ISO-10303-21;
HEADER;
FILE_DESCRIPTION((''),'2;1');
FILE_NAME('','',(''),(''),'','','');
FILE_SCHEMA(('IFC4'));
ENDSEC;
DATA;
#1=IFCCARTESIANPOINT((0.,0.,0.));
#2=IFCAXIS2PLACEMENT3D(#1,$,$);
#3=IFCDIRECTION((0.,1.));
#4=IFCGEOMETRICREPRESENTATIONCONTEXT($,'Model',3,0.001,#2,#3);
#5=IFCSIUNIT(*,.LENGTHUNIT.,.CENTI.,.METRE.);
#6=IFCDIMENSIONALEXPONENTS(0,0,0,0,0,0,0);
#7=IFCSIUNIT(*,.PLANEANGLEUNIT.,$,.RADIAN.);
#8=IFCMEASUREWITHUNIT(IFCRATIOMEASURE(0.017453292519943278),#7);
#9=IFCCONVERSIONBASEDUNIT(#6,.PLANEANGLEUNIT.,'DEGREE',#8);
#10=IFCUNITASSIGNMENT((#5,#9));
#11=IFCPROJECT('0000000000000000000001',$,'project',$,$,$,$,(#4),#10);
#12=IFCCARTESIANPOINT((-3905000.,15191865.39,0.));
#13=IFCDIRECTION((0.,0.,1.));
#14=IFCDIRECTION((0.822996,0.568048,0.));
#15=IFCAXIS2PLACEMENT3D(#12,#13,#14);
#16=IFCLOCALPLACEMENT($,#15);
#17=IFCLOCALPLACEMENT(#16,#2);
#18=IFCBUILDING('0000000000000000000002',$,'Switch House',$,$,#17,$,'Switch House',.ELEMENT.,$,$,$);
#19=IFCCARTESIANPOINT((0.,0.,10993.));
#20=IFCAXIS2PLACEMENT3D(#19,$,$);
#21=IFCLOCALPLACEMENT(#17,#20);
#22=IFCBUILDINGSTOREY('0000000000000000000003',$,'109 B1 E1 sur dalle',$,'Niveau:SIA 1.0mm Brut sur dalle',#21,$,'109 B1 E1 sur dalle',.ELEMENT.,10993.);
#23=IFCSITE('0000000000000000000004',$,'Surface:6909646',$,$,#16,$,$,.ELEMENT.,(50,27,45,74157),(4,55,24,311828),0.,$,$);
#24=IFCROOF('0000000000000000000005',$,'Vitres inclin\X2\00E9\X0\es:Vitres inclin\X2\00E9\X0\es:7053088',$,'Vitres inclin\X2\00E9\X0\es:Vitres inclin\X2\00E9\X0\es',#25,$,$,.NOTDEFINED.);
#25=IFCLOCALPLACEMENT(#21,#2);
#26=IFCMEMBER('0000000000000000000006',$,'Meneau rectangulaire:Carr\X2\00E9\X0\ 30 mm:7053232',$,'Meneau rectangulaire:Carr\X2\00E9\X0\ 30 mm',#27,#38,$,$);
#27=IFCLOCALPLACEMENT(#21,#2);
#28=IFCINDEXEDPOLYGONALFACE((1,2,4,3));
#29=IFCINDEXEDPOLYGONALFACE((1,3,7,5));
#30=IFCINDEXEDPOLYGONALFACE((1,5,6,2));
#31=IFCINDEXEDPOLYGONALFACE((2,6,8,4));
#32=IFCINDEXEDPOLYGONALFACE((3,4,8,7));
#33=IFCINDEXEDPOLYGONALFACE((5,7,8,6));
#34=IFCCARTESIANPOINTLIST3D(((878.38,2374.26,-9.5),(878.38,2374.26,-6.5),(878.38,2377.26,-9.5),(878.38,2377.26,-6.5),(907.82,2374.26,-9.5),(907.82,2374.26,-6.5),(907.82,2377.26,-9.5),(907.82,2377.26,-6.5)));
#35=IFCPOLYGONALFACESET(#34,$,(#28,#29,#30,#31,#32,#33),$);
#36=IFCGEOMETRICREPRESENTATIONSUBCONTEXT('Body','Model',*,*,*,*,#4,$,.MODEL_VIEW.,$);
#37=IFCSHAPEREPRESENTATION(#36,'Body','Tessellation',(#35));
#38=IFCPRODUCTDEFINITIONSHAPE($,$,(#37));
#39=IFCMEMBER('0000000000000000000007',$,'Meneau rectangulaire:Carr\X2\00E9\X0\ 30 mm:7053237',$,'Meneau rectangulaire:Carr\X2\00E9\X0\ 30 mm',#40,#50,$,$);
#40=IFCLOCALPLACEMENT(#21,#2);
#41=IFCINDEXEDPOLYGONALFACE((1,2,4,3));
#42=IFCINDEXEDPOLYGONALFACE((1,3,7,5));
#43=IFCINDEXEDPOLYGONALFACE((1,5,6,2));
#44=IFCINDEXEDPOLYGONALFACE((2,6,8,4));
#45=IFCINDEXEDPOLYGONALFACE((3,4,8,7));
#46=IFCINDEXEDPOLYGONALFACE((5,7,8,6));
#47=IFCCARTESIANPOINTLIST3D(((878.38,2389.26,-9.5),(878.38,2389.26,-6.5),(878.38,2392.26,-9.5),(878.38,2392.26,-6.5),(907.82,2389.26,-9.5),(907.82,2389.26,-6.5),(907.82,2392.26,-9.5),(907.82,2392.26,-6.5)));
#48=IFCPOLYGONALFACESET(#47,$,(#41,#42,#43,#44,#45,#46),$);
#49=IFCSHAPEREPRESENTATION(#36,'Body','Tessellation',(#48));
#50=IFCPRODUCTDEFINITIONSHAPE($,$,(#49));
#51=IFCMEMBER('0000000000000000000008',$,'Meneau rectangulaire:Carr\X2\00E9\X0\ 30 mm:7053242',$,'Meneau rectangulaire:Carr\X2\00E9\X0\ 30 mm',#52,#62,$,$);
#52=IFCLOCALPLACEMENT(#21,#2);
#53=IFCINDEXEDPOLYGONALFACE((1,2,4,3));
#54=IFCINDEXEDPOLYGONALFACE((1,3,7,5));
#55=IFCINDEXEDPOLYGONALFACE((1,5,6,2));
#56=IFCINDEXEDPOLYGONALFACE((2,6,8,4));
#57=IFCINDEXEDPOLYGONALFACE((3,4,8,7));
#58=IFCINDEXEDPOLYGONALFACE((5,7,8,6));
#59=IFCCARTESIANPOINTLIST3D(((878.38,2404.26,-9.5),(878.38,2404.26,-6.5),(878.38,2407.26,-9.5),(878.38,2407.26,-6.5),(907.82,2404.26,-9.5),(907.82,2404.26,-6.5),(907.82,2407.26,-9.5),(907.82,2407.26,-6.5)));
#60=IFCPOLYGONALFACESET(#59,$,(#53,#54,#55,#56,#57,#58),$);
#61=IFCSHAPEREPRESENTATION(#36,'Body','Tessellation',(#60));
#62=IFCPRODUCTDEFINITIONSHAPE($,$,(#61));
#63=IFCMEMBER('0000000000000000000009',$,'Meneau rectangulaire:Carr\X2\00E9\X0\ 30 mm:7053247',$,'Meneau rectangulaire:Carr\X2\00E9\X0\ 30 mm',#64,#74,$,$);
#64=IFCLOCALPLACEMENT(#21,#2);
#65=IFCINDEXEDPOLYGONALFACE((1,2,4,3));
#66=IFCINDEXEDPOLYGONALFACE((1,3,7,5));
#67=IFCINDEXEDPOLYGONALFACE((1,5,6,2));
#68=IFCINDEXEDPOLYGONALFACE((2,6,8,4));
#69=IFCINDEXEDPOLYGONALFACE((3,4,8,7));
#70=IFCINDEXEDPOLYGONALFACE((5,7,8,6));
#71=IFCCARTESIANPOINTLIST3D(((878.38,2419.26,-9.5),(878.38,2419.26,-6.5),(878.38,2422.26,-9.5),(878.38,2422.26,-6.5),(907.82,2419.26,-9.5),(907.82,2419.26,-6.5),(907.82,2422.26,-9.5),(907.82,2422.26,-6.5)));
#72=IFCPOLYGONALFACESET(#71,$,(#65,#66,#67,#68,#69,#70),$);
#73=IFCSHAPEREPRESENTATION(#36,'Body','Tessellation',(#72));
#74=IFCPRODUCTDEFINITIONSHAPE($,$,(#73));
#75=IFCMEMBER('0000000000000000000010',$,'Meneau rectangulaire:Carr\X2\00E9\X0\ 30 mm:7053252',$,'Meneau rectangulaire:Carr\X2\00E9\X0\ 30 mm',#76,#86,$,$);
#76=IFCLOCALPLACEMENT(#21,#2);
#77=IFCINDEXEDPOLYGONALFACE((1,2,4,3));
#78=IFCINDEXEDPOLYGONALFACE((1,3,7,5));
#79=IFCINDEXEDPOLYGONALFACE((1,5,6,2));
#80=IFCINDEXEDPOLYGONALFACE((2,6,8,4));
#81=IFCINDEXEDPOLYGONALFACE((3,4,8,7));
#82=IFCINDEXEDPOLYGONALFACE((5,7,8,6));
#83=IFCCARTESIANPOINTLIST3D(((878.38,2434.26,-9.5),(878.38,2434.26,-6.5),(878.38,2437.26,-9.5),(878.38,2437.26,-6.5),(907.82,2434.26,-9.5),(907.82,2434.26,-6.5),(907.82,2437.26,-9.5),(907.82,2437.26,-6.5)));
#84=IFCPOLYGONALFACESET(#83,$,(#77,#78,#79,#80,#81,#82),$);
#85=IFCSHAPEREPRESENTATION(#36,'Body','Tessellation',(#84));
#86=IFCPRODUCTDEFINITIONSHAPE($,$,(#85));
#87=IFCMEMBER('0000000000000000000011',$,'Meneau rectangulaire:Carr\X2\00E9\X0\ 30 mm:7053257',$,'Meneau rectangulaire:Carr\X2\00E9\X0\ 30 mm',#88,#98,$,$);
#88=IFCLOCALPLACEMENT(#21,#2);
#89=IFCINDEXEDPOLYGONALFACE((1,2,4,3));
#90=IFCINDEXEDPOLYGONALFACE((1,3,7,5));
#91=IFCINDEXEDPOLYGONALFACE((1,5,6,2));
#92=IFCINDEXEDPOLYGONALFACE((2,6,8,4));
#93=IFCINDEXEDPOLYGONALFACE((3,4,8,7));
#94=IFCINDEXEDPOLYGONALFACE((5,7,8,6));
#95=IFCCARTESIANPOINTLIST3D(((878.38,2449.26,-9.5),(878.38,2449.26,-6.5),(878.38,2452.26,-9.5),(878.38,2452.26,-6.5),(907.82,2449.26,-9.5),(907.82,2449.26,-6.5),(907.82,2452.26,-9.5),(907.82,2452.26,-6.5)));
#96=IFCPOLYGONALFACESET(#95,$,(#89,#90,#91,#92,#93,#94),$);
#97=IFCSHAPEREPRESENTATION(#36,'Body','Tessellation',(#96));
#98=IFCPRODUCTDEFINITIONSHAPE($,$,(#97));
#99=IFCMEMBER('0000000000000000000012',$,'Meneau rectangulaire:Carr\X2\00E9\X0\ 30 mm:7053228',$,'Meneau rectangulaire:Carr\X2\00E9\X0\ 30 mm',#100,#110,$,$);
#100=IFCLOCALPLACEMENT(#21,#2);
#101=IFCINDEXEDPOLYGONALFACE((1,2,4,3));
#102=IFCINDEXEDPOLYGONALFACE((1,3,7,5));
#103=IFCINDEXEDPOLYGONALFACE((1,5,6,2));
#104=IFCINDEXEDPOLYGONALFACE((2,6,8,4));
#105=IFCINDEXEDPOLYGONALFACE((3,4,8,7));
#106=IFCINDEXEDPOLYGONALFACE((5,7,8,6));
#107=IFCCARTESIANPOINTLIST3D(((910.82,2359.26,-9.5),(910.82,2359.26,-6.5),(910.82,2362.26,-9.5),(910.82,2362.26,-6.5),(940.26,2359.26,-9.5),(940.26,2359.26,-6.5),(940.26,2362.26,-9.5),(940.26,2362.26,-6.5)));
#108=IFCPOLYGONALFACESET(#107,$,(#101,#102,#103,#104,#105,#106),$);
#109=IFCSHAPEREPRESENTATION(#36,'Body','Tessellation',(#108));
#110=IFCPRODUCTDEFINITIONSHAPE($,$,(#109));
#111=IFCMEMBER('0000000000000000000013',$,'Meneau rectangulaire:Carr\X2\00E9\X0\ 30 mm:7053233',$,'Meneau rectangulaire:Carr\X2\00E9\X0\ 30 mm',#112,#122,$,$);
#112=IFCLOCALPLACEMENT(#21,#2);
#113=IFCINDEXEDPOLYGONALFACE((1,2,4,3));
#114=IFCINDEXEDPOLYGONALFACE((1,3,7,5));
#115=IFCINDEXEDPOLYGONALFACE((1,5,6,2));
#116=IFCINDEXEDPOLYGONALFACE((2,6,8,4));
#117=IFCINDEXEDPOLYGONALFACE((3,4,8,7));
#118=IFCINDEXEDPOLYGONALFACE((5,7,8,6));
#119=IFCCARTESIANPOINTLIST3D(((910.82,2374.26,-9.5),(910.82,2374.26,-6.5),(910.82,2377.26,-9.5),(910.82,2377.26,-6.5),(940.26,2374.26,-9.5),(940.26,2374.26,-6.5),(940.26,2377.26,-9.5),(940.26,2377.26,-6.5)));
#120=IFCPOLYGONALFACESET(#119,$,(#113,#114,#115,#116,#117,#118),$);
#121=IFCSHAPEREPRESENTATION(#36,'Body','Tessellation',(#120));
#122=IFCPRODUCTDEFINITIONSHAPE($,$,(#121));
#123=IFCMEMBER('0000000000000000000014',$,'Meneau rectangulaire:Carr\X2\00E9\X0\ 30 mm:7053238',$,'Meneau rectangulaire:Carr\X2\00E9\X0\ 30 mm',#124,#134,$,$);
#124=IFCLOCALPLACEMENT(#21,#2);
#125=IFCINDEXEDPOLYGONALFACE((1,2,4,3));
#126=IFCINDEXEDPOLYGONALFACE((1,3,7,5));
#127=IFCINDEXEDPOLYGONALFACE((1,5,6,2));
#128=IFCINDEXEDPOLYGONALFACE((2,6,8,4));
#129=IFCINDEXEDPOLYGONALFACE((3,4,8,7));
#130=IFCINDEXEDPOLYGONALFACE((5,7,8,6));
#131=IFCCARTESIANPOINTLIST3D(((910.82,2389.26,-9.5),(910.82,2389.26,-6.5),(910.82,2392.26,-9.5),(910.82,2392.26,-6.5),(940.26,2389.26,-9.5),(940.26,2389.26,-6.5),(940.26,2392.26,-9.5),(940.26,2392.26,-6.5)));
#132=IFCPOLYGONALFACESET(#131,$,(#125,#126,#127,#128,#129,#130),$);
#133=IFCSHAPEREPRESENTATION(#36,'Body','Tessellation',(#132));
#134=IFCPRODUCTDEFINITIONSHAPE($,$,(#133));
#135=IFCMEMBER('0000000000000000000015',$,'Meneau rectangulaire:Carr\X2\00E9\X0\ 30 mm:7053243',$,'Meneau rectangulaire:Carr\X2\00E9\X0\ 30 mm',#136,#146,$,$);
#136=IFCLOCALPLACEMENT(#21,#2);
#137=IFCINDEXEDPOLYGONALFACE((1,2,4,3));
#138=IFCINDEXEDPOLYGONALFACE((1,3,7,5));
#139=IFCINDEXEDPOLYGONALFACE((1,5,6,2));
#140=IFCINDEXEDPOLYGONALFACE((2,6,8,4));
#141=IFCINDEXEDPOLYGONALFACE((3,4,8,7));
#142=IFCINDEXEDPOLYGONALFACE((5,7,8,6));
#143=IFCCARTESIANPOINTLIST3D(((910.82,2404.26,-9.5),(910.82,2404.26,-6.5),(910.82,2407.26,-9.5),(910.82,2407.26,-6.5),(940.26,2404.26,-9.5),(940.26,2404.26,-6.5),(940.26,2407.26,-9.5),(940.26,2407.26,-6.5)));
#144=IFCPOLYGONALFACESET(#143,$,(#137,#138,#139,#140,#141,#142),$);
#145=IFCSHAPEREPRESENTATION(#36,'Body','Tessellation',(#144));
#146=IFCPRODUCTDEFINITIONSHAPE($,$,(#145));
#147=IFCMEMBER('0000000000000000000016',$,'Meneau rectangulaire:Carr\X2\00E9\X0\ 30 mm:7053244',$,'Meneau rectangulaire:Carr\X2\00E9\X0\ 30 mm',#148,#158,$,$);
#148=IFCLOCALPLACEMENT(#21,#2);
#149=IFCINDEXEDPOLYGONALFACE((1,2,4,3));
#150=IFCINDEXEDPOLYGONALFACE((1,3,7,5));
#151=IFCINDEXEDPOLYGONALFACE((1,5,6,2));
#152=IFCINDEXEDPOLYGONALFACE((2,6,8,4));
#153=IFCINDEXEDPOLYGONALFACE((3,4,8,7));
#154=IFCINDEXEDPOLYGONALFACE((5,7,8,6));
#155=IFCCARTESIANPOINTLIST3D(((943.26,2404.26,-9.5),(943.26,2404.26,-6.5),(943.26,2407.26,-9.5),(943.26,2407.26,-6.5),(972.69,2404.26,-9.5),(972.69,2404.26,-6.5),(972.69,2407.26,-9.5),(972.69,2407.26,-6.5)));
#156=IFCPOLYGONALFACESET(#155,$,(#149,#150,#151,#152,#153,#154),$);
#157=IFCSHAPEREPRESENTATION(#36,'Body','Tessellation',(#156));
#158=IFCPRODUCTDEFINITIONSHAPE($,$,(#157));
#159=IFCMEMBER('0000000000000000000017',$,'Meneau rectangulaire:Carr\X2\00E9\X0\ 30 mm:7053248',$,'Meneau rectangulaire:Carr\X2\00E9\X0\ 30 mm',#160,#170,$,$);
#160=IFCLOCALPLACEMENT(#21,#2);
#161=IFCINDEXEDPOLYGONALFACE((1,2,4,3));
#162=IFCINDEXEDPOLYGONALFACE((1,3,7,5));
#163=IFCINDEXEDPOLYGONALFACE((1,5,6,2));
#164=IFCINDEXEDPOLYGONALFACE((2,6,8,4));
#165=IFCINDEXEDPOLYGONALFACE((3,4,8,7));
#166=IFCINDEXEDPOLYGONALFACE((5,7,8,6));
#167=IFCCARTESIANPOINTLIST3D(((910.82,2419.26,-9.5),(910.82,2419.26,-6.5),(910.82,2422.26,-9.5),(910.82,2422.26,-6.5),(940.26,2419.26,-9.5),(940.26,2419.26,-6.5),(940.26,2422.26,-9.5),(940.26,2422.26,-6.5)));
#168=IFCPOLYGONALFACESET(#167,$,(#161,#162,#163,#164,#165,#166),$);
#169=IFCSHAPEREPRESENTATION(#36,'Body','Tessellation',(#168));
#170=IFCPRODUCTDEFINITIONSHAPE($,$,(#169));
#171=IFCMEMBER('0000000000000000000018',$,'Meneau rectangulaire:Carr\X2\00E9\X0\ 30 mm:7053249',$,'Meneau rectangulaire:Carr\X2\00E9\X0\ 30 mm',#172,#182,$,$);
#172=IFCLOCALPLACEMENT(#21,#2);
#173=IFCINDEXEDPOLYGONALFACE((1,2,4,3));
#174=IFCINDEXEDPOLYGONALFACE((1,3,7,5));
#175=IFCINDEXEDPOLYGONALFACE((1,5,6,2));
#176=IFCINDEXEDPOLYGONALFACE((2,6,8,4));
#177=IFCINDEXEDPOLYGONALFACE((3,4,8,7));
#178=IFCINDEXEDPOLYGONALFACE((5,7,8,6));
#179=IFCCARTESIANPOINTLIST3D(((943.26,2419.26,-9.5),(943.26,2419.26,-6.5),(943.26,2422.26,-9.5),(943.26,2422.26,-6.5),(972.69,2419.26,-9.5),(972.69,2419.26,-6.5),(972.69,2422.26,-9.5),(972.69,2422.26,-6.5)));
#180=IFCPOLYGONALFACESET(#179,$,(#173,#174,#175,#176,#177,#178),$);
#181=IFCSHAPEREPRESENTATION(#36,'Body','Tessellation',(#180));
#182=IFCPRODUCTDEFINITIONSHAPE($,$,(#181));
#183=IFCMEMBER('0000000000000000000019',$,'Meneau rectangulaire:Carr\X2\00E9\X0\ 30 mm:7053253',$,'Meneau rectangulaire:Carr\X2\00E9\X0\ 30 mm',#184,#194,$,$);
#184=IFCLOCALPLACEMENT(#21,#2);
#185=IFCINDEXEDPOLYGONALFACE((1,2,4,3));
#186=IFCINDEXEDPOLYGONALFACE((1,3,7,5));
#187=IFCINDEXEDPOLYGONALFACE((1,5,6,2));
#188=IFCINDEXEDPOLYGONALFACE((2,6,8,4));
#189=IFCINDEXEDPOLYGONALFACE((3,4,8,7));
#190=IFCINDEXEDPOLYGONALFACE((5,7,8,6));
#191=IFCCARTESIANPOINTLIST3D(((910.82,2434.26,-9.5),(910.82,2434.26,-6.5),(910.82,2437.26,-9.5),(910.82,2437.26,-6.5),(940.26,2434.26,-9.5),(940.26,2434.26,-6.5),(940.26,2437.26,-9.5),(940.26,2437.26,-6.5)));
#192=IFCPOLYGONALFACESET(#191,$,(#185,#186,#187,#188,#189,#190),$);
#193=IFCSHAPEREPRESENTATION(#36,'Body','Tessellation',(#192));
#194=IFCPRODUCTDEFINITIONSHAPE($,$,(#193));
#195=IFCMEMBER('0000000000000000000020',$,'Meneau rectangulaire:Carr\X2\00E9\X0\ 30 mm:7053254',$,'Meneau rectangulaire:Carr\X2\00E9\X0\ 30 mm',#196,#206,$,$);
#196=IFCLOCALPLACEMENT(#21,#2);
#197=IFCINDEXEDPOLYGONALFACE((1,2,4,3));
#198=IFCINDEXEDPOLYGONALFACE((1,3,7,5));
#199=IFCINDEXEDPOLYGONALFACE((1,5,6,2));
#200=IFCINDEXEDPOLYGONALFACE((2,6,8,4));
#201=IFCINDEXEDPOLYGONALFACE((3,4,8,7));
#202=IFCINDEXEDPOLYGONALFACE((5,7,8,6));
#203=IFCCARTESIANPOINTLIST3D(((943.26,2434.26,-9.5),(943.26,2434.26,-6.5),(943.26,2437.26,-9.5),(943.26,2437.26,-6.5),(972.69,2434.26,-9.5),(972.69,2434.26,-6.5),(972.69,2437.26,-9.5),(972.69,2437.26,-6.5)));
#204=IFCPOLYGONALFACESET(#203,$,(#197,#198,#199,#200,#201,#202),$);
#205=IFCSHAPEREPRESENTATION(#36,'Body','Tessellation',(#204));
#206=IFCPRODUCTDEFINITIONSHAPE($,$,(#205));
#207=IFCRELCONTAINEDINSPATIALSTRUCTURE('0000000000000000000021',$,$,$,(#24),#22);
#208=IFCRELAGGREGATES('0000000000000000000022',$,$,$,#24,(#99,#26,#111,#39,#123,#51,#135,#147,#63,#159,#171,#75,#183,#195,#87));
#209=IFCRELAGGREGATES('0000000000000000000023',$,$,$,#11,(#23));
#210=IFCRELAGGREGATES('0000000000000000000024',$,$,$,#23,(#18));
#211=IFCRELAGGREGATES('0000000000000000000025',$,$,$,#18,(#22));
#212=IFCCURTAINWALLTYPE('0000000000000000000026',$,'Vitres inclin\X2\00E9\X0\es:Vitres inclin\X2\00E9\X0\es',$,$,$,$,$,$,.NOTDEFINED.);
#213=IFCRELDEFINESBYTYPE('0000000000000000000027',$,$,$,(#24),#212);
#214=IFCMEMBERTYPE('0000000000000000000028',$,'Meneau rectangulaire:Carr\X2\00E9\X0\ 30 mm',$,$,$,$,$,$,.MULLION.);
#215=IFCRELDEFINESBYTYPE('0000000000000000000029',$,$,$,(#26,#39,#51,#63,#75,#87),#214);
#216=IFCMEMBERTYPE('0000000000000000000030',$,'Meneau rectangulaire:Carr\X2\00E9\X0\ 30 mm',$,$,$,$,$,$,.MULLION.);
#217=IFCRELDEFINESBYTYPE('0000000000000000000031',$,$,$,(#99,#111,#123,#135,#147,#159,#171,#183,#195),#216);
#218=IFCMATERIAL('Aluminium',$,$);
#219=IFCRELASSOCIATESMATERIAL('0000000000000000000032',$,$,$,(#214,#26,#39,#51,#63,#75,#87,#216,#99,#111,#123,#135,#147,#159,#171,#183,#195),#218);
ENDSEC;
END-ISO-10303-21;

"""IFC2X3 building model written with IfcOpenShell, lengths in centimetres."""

from ifc_helpers import new_model, entity, si_unit, converted_unit, direction, frame, origin, origin_2d_with_axis, place, context, subcontext, project, spatial, rectangle, extrude, source, transform, mapped, material, type_object, type_shapes, element, aggregate, save


model = new_model("IFC2X3")

# Units and contexts
model_context = context("Model", 3, precision=0.001, world=origin(), true_north=direction((0.0, 1.0)))
body_context = subcontext(model_context, "Body", "Model", "MODEL_VIEW")
ifc_project = project(units=[si_unit("LENGTHUNIT", "METRE", prefix="CENTI"), converted_unit("PLANEANGLEUNIT", "DEGREE", entity("IfcRatioMeasure", 0.017453292519943278), si_unit("PLANEANGLEUNIT", "RADIAN"), dimensions=[0, 0, 0, 0, 0, 0, 0])], contexts=[model_context])

# Site, building, storey
site_placement = place(None, frame((-3905000.0, 15191865.39, 0.0), z_axis=(0.0, 0.0, 1.0), x_axis=(0.822996, 0.568048, 0.0)))
site = spatial("IfcSite", under=ifc_project, at=site_placement, Name="Surface:6909646", CompositionType="ELEMENT", RefLatitude=(50, 27, 45, 74157), RefLongitude=(4, 55, 24, 311828), RefElevation=0.0)
building_placement = place(site_placement, origin())
building = spatial("IfcBuilding", under=site, at=building_placement, Name="Switch House", LongName="Switch House", CompositionType="ELEMENT")
storey_placement = place(building_placement, frame((0.0, 0.0, 10993.0)))
storey = spatial("IfcBuildingStorey", under=building, at=storey_placement, Name="109 B1 E1 sur dalle", ObjectType="Niveau:SIA 1.0mm Brut sur dalle", LongName="109 B1 E1 sur dalle", CompositionType="ELEMENT", Elevation=10993.0)

# Roof, members
curtain_wall_type = type_object("IfcCurtainWallType", Name="Vitres inclinées:Vitres inclinées", PredefinedType="NOTDEFINED")
roof_placement = place(storey_placement, frame((0.0, 0.0, -10993.0)))
roof = element("IfcRoof", 1, at=roof_placement, inside=storey, type_object=curtain_wall_type, Name="Vitres inclinées:Vitres inclinées:7053088", ObjectType="Vitres inclinées:Vitres inclinées", ShapeType="NOTDEFINED")
ifc_material = material(Name="Aluminium")
member_type_1 = type_object("IfcMemberType", Name="Meneau rectangulaire:Carré 30 mm", PredefinedType="MULLION", material=ifc_material)
shared_shape_1 = source(origin(), body_context, "Body", "SweptSolid", [
    extrude(rectangle(XDim=3.0, YDim=3.0, at=origin_2d_with_axis()), frame((0.0, 0.0, -29.44), z_axis=(0.0, 0.0, 1.0), x_axis=(0.0, -1.0, 0.0)), (0.0, 0.0, 1.0), 29.44),
])
type_shapes(member_type_1, [shared_shape_1])
member_1_placement = place(roof_placement, frame((878.38, 2375.76, 10985.0), z_axis=(-1.0, 0.0, 0.0), x_axis=(0.0, 1.0, 0.0)))
member_1 = element("IfcMember", 2, at=member_1_placement, type_object=member_type_1, material=ifc_material, Name="Meneau rectangulaire:Carré 30 mm:7053232", ObjectType="Meneau rectangulaire:Carré 30 mm", context=body_context, shape_type="MappedRepresentation", body=[
    mapped(shared_shape_1, transform((0.0, 0.0, 0.0), scale=1.0)),
])
member_2_placement = place(roof_placement, frame((878.38, 2390.76, 10985.0), z_axis=(-1.0, 0.0, 0.0), x_axis=(0.0, 1.0, 0.0)))
member_2 = element("IfcMember", 3, at=member_2_placement, type_object=member_type_1, material=ifc_material, Name="Meneau rectangulaire:Carré 30 mm:7053237", ObjectType="Meneau rectangulaire:Carré 30 mm", context=body_context, shape_type="MappedRepresentation", body=[
    mapped(shared_shape_1, transform((0.0, 0.0, 0.0), scale=1.0)),
])
member_3_placement = place(roof_placement, frame((878.38, 2405.76, 10985.0), z_axis=(-1.0, 0.0, 0.0), x_axis=(0.0, 1.0, 0.0)))
member_3 = element("IfcMember", 4, at=member_3_placement, type_object=member_type_1, material=ifc_material, Name="Meneau rectangulaire:Carré 30 mm:7053242", ObjectType="Meneau rectangulaire:Carré 30 mm", context=body_context, shape_type="MappedRepresentation", body=[
    mapped(shared_shape_1, transform((0.0, 0.0, 0.0), scale=1.0)),
])
member_4_placement = place(roof_placement, frame((878.38, 2420.76, 10985.0), z_axis=(-1.0, 0.0, 0.0), x_axis=(0.0, 1.0, 0.0)))
member_4 = element("IfcMember", 5, at=member_4_placement, type_object=member_type_1, material=ifc_material, Name="Meneau rectangulaire:Carré 30 mm:7053247", ObjectType="Meneau rectangulaire:Carré 30 mm", context=body_context, shape_type="MappedRepresentation", body=[
    mapped(shared_shape_1, transform((0.0, 0.0, 0.0), scale=1.0)),
])
member_5_placement = place(roof_placement, frame((878.38, 2435.76, 10985.0), z_axis=(-1.0, 0.0, 0.0), x_axis=(0.0, 1.0, 0.0)))
member_5 = element("IfcMember", 6, at=member_5_placement, type_object=member_type_1, material=ifc_material, Name="Meneau rectangulaire:Carré 30 mm:7053252", ObjectType="Meneau rectangulaire:Carré 30 mm", context=body_context, shape_type="MappedRepresentation", body=[
    mapped(shared_shape_1, transform((0.0, 0.0, 0.0), scale=1.0)),
])
member_6_placement = place(roof_placement, frame((878.38, 2450.76, 10985.0), z_axis=(-1.0, 0.0, 0.0), x_axis=(0.0, 1.0, 0.0)))
member_6 = element("IfcMember", 7, at=member_6_placement, type_object=member_type_1, material=ifc_material, Name="Meneau rectangulaire:Carré 30 mm:7053257", ObjectType="Meneau rectangulaire:Carré 30 mm", context=body_context, shape_type="MappedRepresentation", body=[
    mapped(shared_shape_1, transform((0.0, 0.0, 0.0), scale=1.0)),
])
member_type_2 = type_object("IfcMemberType", Name="Meneau rectangulaire:Carré 30 mm", PredefinedType="MULLION", material=ifc_material)
shared_shape_2 = source(origin(), body_context, "Body", "SweptSolid", [
    extrude(rectangle(XDim=3.0, YDim=3.0, at=origin_2d_with_axis()), frame((0.0, 0.0, -29.44), z_axis=(0.0, 0.0, 1.0), x_axis=(0.0, -1.0, 0.0)), (0.0, 0.0, 1.0), 29.44),
])
type_shapes(member_type_2, [shared_shape_2])
member_7_placement = place(roof_placement, frame((910.82, 2360.76, 10985.0), z_axis=(-1.0, 0.0, 0.0), x_axis=(0.0, 1.0, 0.0)))
member_7 = element("IfcMember", 8, at=member_7_placement, type_object=member_type_2, material=ifc_material, Name="Meneau rectangulaire:Carré 30 mm:7053228", ObjectType="Meneau rectangulaire:Carré 30 mm", context=body_context, shape_type="MappedRepresentation", body=[
    mapped(shared_shape_2, transform((0.0, 0.0, 0.0), scale=1.0)),
])
member_8_placement = place(roof_placement, frame((910.82, 2375.76, 10985.0), z_axis=(-1.0, 0.0, 0.0), x_axis=(0.0, 1.0, 0.0)))
member_8 = element("IfcMember", 9, at=member_8_placement, type_object=member_type_2, material=ifc_material, Name="Meneau rectangulaire:Carré 30 mm:7053233", ObjectType="Meneau rectangulaire:Carré 30 mm", context=body_context, shape_type="MappedRepresentation", body=[
    mapped(shared_shape_2, transform((0.0, 0.0, 0.0), scale=1.0)),
])
member_9_placement = place(roof_placement, frame((910.82, 2390.76, 10985.0), z_axis=(-1.0, 0.0, 0.0), x_axis=(0.0, 1.0, 0.0)))
member_9 = element("IfcMember", 10, at=member_9_placement, type_object=member_type_2, material=ifc_material, Name="Meneau rectangulaire:Carré 30 mm:7053238", ObjectType="Meneau rectangulaire:Carré 30 mm", context=body_context, shape_type="MappedRepresentation", body=[
    mapped(shared_shape_2, transform((0.0, 0.0, 0.0), scale=1.0)),
])
member_10_placement = place(roof_placement, frame((910.82, 2405.76, 10985.0), z_axis=(-1.0, 0.0, 0.0), x_axis=(0.0, 1.0, 0.0)))
member_10 = element("IfcMember", 11, at=member_10_placement, type_object=member_type_2, material=ifc_material, Name="Meneau rectangulaire:Carré 30 mm:7053243", ObjectType="Meneau rectangulaire:Carré 30 mm", context=body_context, shape_type="MappedRepresentation", body=[
    mapped(shared_shape_2, transform((0.0, 0.0, 0.0), scale=1.0)),
])
member_11_placement = place(roof_placement, frame((943.26, 2405.76, 10985.0), z_axis=(-1.0, 0.0, 0.0), x_axis=(0.0, 1.0, 0.0)))
member_11 = element("IfcMember", 12, at=member_11_placement, type_object=member_type_2, material=ifc_material, Name="Meneau rectangulaire:Carré 30 mm:7053244", ObjectType="Meneau rectangulaire:Carré 30 mm", context=body_context, shape_type="MappedRepresentation", body=[
    mapped(shared_shape_2, transform((0.0, 0.0, 0.0), scale=1.0)),
])
member_12_placement = place(roof_placement, frame((910.82, 2420.76, 10985.0), z_axis=(-1.0, 0.0, 0.0), x_axis=(0.0, 1.0, 0.0)))
member_12 = element("IfcMember", 13, at=member_12_placement, type_object=member_type_2, material=ifc_material, Name="Meneau rectangulaire:Carré 30 mm:7053248", ObjectType="Meneau rectangulaire:Carré 30 mm", context=body_context, shape_type="MappedRepresentation", body=[
    mapped(shared_shape_2, transform((0.0, 0.0, 0.0), scale=1.0)),
])
member_13_placement = place(roof_placement, frame((943.26, 2420.76, 10985.0), z_axis=(-1.0, 0.0, 0.0), x_axis=(0.0, 1.0, 0.0)))
member_13 = element("IfcMember", 14, at=member_13_placement, type_object=member_type_2, material=ifc_material, Name="Meneau rectangulaire:Carré 30 mm:7053249", ObjectType="Meneau rectangulaire:Carré 30 mm", context=body_context, shape_type="MappedRepresentation", body=[
    mapped(shared_shape_2, transform((0.0, 0.0, 0.0), scale=1.0)),
])
member_14_placement = place(roof_placement, frame((910.82, 2435.76, 10985.0), z_axis=(-1.0, 0.0, 0.0), x_axis=(0.0, 1.0, 0.0)))
member_14 = element("IfcMember", 15, at=member_14_placement, type_object=member_type_2, material=ifc_material, Name="Meneau rectangulaire:Carré 30 mm:7053253", ObjectType="Meneau rectangulaire:Carré 30 mm", context=body_context, shape_type="MappedRepresentation", body=[
    mapped(shared_shape_2, transform((0.0, 0.0, 0.0), scale=1.0)),
])
member_15_placement = place(roof_placement, frame((943.26, 2435.76, 10985.0), z_axis=(-1.0, 0.0, 0.0), x_axis=(0.0, 1.0, 0.0)))
member_15 = element("IfcMember", 16, at=member_15_placement, type_object=member_type_2, material=ifc_material, Name="Meneau rectangulaire:Carré 30 mm:7053254", ObjectType="Meneau rectangulaire:Carré 30 mm", context=body_context, shape_type="MappedRepresentation", body=[
    mapped(shared_shape_2, transform((0.0, 0.0, 0.0), scale=1.0)),
])
aggregate(roof, [member_7, member_1, member_8, member_2, member_9, member_3, member_10, member_11, member_4, member_12, member_13, member_5, member_14, member_15, member_6])

save(model, "model.ifc")
